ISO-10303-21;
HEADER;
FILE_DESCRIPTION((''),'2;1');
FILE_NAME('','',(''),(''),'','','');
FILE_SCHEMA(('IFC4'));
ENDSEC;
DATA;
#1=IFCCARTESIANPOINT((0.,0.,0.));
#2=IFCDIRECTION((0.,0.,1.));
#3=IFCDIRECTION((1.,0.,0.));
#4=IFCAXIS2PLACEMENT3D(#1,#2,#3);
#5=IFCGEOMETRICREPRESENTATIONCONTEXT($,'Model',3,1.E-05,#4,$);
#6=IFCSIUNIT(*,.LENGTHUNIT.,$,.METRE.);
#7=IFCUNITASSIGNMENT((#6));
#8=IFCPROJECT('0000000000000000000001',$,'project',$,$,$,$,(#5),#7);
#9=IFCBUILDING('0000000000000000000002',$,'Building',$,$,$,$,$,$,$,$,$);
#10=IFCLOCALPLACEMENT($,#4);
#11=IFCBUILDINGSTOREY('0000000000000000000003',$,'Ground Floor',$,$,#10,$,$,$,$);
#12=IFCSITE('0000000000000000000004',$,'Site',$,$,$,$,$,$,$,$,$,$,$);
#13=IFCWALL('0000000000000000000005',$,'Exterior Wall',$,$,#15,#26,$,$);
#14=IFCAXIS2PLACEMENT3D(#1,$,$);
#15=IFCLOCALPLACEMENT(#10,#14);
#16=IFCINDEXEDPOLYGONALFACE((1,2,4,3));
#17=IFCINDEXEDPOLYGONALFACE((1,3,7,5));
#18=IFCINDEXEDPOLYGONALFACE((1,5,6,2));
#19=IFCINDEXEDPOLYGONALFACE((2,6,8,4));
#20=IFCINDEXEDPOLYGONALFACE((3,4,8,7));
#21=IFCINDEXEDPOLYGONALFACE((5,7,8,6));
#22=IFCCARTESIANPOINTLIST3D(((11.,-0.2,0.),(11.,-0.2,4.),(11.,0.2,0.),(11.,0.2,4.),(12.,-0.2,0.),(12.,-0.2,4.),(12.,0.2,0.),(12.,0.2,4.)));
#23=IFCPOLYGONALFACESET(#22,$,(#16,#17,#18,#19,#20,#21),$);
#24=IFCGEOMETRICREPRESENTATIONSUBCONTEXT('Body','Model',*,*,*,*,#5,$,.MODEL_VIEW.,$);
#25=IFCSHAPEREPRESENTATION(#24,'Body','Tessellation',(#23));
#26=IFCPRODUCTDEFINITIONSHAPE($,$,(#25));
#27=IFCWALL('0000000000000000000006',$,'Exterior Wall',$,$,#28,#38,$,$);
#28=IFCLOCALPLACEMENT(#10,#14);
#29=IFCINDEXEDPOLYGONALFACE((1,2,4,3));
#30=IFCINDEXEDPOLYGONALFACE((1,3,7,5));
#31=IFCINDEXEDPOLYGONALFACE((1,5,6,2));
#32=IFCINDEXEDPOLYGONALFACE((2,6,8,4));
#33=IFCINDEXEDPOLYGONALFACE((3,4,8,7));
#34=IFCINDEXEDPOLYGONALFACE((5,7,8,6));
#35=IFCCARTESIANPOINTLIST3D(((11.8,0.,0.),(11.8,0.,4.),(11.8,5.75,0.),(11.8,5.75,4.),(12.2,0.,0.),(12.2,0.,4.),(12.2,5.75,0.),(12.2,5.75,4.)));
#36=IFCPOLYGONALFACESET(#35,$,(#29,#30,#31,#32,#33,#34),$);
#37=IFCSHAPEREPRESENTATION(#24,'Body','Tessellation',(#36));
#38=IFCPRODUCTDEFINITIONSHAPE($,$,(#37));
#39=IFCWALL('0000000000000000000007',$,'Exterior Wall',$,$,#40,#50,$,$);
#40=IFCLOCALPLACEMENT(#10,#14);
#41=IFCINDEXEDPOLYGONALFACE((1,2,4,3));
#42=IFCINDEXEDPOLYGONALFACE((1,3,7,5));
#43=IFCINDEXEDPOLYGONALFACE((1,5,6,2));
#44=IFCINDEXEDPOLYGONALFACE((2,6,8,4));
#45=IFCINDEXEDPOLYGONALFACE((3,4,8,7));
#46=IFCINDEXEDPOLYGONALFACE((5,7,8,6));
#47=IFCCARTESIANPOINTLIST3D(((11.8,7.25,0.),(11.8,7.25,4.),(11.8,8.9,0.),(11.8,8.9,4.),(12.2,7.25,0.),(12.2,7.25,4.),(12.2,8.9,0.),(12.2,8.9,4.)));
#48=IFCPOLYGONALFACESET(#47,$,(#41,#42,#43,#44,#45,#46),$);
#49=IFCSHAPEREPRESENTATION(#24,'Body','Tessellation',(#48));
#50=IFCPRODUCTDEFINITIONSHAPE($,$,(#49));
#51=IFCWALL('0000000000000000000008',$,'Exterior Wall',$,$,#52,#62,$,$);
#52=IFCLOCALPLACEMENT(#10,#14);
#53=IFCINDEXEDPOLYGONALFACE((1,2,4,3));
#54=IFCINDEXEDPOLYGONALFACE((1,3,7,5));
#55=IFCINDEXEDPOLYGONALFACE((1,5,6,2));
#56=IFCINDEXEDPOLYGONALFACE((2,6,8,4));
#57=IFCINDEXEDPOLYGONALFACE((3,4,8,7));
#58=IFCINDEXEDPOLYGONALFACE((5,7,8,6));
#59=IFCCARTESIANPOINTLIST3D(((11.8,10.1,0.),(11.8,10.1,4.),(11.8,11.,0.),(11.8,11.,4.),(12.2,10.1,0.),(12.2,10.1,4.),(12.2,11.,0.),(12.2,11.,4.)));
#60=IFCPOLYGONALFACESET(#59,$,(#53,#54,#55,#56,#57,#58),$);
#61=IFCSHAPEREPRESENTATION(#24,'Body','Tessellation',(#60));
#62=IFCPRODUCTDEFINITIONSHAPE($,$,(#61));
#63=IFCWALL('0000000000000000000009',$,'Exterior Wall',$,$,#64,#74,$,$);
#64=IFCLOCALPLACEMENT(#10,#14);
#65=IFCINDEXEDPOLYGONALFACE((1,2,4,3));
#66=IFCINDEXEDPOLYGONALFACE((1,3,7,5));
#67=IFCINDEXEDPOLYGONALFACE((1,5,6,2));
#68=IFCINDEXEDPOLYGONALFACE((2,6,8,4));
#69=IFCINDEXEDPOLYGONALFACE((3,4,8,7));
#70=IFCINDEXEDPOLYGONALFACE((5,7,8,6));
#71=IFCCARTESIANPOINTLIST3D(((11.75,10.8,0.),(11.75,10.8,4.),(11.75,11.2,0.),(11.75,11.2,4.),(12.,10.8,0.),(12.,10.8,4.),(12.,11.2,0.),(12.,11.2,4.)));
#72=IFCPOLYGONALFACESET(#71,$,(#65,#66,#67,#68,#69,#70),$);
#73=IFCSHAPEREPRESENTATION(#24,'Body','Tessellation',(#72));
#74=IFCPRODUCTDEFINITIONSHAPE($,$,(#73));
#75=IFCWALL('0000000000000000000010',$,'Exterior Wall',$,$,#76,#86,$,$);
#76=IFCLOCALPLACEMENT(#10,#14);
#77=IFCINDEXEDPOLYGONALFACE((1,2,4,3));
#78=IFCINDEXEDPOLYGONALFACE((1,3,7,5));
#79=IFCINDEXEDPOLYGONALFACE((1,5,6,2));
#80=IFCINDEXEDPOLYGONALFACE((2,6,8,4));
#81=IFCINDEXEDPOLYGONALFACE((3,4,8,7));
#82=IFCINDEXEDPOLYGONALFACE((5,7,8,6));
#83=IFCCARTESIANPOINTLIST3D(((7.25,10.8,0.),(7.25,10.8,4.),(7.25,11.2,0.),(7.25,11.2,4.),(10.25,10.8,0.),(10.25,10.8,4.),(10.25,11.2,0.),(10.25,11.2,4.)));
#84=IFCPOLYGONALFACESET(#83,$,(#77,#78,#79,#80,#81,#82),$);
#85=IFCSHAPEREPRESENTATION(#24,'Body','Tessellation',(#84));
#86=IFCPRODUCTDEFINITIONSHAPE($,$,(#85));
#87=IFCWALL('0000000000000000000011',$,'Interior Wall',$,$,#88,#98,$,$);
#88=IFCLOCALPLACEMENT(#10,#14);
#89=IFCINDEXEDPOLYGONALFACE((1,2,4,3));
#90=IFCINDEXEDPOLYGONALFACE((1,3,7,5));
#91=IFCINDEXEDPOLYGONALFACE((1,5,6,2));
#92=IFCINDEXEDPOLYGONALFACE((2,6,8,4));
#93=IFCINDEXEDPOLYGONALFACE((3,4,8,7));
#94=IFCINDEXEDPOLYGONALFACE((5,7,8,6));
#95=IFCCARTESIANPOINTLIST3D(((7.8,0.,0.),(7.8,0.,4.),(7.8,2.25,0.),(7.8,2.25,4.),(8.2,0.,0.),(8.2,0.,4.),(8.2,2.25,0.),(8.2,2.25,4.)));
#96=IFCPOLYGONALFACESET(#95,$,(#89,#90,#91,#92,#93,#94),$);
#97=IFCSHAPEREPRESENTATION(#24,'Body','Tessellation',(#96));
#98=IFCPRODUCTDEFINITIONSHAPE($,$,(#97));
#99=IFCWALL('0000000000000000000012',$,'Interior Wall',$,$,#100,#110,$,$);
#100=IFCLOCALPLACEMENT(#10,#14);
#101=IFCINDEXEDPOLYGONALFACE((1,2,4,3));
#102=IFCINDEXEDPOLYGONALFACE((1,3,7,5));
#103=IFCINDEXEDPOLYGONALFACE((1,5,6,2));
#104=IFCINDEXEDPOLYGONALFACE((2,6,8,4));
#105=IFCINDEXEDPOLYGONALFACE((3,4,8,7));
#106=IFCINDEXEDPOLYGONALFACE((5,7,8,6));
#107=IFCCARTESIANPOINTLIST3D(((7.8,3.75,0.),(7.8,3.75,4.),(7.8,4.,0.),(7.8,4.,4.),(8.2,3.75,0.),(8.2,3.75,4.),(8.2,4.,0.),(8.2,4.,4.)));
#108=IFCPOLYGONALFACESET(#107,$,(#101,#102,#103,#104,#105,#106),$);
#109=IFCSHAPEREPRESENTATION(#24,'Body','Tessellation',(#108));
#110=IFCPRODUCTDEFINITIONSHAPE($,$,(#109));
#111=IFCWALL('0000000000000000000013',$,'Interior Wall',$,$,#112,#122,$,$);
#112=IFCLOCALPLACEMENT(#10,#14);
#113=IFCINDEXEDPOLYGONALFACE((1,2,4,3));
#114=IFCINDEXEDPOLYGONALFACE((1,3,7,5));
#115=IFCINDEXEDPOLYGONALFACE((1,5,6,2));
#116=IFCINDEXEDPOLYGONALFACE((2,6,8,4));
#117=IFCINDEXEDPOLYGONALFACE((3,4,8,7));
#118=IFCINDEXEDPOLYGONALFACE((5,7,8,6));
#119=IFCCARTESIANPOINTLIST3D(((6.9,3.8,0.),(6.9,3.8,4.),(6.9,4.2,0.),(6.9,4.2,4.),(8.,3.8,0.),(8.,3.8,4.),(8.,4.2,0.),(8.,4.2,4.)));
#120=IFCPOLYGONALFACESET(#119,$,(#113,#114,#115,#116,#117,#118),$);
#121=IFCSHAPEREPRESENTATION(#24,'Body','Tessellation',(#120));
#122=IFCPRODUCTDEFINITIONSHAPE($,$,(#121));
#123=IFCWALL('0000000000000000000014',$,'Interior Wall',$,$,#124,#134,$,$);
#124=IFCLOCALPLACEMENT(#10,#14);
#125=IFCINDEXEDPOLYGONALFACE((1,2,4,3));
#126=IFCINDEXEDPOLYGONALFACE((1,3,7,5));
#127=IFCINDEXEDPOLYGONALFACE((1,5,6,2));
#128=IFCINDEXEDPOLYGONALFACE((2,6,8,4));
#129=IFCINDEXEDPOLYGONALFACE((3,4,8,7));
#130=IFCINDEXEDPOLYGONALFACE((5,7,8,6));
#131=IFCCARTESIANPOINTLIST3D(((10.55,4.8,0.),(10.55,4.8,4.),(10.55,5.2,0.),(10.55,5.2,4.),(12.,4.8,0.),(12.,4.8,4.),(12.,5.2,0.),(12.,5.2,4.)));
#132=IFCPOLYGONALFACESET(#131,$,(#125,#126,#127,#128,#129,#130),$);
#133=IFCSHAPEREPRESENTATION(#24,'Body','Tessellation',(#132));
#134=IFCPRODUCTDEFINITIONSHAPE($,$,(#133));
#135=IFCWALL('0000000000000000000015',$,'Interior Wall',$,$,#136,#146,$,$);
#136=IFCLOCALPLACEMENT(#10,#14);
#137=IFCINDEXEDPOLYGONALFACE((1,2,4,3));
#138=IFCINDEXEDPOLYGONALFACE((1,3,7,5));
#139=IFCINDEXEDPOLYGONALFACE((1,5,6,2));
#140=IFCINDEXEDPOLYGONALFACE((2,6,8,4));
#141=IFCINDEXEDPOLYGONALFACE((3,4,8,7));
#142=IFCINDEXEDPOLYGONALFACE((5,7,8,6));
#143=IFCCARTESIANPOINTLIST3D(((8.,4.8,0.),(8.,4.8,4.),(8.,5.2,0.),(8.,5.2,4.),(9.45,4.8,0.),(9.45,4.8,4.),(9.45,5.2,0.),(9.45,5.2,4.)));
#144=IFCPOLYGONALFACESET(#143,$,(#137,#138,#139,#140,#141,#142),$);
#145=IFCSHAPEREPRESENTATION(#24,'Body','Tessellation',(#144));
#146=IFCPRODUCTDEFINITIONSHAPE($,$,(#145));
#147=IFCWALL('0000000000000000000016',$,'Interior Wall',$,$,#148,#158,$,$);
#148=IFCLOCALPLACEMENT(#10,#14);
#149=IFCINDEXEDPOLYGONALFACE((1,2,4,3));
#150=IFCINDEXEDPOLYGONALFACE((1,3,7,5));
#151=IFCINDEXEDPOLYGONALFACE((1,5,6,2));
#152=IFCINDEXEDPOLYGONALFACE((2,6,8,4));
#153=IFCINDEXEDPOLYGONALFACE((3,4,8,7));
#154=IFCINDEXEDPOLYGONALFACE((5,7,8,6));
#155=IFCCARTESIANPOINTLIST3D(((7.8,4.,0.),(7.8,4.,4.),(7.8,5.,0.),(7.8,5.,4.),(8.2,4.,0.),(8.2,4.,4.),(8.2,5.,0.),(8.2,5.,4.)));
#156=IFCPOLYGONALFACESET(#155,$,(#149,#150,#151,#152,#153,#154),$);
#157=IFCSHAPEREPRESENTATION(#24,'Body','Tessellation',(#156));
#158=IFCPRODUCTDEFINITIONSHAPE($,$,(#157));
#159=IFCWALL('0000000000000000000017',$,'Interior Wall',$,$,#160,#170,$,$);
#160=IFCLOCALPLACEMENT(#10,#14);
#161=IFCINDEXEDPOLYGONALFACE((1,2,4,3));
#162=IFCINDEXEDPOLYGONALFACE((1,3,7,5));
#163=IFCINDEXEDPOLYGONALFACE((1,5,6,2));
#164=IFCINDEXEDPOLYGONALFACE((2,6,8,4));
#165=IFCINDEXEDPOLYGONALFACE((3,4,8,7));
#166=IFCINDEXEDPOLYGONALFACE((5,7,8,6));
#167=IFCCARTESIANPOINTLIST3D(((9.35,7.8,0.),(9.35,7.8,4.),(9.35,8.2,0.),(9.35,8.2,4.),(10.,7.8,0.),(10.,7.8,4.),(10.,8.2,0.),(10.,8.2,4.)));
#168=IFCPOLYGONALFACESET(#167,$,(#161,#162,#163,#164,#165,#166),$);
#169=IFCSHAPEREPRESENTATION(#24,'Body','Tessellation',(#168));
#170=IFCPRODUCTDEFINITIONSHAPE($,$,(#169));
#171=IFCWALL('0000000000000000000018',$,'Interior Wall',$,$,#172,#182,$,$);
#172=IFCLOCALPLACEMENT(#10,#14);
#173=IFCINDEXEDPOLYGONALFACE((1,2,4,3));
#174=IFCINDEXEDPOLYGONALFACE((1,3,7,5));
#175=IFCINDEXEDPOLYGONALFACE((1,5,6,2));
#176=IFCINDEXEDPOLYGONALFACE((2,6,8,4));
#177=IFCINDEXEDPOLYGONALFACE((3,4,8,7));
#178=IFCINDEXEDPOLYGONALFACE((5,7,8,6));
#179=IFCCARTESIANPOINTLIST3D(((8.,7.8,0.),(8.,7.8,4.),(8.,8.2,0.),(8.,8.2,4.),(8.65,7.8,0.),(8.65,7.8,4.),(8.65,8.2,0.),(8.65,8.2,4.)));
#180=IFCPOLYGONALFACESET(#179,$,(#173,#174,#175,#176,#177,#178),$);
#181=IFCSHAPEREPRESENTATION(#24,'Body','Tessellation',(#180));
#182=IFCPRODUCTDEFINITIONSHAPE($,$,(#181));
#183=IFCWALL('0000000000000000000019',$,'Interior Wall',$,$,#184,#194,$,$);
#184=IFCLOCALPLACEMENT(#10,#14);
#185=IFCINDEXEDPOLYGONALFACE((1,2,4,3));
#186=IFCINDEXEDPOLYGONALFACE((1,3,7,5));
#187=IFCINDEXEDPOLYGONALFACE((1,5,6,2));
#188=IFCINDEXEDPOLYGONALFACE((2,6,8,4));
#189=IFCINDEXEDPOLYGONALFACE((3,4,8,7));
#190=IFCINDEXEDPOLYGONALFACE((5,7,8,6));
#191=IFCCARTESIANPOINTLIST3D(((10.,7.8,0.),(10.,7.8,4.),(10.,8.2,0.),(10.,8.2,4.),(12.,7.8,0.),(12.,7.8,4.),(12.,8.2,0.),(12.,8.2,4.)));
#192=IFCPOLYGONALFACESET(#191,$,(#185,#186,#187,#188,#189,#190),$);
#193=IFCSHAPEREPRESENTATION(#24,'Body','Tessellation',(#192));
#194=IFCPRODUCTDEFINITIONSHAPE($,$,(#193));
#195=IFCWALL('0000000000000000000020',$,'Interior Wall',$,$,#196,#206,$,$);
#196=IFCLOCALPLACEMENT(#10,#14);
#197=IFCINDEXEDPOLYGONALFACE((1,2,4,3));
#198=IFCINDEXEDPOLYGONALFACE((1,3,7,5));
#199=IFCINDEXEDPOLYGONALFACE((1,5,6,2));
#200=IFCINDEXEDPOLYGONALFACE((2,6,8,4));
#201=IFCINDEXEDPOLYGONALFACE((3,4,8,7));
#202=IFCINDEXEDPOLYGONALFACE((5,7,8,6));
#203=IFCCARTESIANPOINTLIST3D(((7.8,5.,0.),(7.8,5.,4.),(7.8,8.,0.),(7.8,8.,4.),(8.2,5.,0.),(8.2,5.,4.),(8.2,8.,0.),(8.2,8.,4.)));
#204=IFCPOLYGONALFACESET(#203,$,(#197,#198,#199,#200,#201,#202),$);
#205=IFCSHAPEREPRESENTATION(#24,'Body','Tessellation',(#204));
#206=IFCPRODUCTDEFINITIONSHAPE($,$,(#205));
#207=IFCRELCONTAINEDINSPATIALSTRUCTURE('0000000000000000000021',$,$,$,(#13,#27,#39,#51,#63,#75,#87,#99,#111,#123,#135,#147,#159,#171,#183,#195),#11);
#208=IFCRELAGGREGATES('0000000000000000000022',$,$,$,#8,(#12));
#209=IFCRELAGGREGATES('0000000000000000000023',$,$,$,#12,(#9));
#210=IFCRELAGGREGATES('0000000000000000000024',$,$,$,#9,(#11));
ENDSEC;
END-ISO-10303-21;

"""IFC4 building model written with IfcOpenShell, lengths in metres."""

from ifc_helpers import new_model, si_unit, frame, origin_with_axes, place, context, subcontext, project, spatial, indexed_curve, outline, extrude, element, save


model = new_model("IFC4")

# Units and contexts
model_context = context("Model", 3, precision=1e-05, world=origin_with_axes())
body_context = subcontext(model_context, "Body", "Model", "MODEL_VIEW")
ifc_project = project(units=[si_unit("LENGTHUNIT", "METRE")], contexts=[model_context])

# Site, building, storey
site = spatial("IfcSite", under=ifc_project, Name="Site")
building = spatial("IfcBuilding", under=site, Name="Building")
storey_placement = place(None, origin_with_axes())
storey = spatial("IfcBuildingStorey", under=building, at=storey_placement, Name="Ground Floor")

# Walls
wall_1_placement = place(storey_placement, frame((11.0, 0.0, 0.0), z_axis=(0.0, 0.0, 1.0), x_axis=(1.0, 0.0, 0.0)))
element("IfcWall", 1, at=wall_1_placement, inside=storey, Name="Exterior Wall", context=body_context, shape_type="SweptSolid", body=[
    extrude(outline(indexed_curve([(0.0, 0.0), (0.0, 0.4), (1.0, 0.4), (1.0, 0.0), (0.0, 0.0)], self_intersect=False)), frame((0.0, -0.2, 0.0), z_axis=(0.0, 0.0, 1.0), x_axis=(1.0, 0.0, 0.0)), (0.0, 0.0, 1.0), 4.0),
])
wall_2_placement = place(storey_placement, frame((12.0, 0.0, 0.0), z_axis=(0.0, 0.0, 1.0), x_axis=(0.0, 1.0, 0.0)))
element("IfcWall", 2, at=wall_2_placement, inside=storey, Name="Exterior Wall", context=body_context, shape_type="SweptSolid", body=[
    extrude(outline(indexed_curve([(0.0, 0.0), (0.0, 0.4), (5.75, 0.4), (5.75, 0.0), (0.0, 0.0)], self_intersect=False)), frame((0.0, -0.2, 0.0), z_axis=(0.0, 0.0, 1.0), x_axis=(1.0, 0.0, 0.0)), (0.0, 0.0, 1.0), 4.0),
])
wall_3_placement = place(storey_placement, frame((12.0, 7.25, 0.0), z_axis=(0.0, 0.0, 1.0), x_axis=(0.0, 1.0, 0.0)))
element("IfcWall", 3, at=wall_3_placement, inside=storey, Name="Exterior Wall", context=body_context, shape_type="SweptSolid", body=[
    extrude(outline(indexed_curve([(0.0, 0.0), (0.0, 0.4), (1.65, 0.4), (1.65, 0.0), (0.0, 0.0)], self_intersect=False)), frame((0.0, -0.2, 0.0), z_axis=(0.0, 0.0, 1.0), x_axis=(1.0, 0.0, 0.0)), (0.0, 0.0, 1.0), 4.0),
])
wall_4_placement = place(storey_placement, frame((12.0, 10.1, 0.0), z_axis=(0.0, 0.0, 1.0), x_axis=(0.0, 1.0, 0.0)))
element("IfcWall", 4, at=wall_4_placement, inside=storey, Name="Exterior Wall", context=body_context, shape_type="SweptSolid", body=[
    extrude(outline(indexed_curve([(0.0, 0.0), (0.0, 0.4), (0.9, 0.4), (0.9, 0.0), (0.0, 0.0)], self_intersect=False)), frame((0.0, -0.2, 0.0), z_axis=(0.0, 0.0, 1.0), x_axis=(1.0, 0.0, 0.0)), (0.0, 0.0, 1.0), 4.0),
])
wall_5_placement = place(storey_placement, frame((12.0, 11.0, 0.0), z_axis=(0.0, 0.0, 1.0), x_axis=(-1.0, 0.0, 0.0)))
element("IfcWall", 5, at=wall_5_placement, inside=storey, Name="Exterior Wall", context=body_context, shape_type="SweptSolid", body=[
    extrude(outline(indexed_curve([(0.0, 0.0), (0.0, 0.4), (0.25, 0.4), (0.25, 0.0), (0.0, 0.0)], self_intersect=False)), frame((0.0, -0.2, 0.0), z_axis=(0.0, 0.0, 1.0), x_axis=(1.0, 0.0, 0.0)), (0.0, 0.0, 1.0), 4.0),
])
wall_6_placement = place(storey_placement, frame((10.25, 11.0, 0.0), z_axis=(0.0, 0.0, 1.0), x_axis=(-1.0, 0.0, 0.0)))
element("IfcWall", 6, at=wall_6_placement, inside=storey, Name="Exterior Wall", context=body_context, shape_type="SweptSolid", body=[
    extrude(outline(indexed_curve([(0.0, 0.0), (0.0, 0.4), (3.0, 0.4), (3.0, 0.0), (0.0, 0.0)], self_intersect=False)), frame((0.0, -0.2, 0.0), z_axis=(0.0, 0.0, 1.0), x_axis=(1.0, 0.0, 0.0)), (0.0, 0.0, 1.0), 4.0),
])
wall_7_placement = place(storey_placement, frame((8.0, 0.0, 0.0), z_axis=(0.0, 0.0, 1.0), x_axis=(0.0, 1.0, 0.0)))
element("IfcWall", 7, at=wall_7_placement, inside=storey, Name="Interior Wall", context=body_context, shape_type="SweptSolid", body=[
    extrude(outline(indexed_curve([(0.0, 0.0), (0.0, 0.4), (2.25, 0.4), (2.25, 0.0), (0.0, 0.0)], self_intersect=False)), frame((0.0, -0.2, 0.0), z_axis=(0.0, 0.0, 1.0), x_axis=(1.0, 0.0, 0.0)), (0.0, 0.0, 1.0), 4.0),
])
wall_8_placement = place(storey_placement, frame((8.0, 3.75, 0.0), z_axis=(0.0, 0.0, 1.0), x_axis=(0.0, 1.0, 0.0)))
element("IfcWall", 8, at=wall_8_placement, inside=storey, Name="Interior Wall", context=body_context, shape_type="SweptSolid", body=[
    extrude(outline(indexed_curve([(0.0, 0.0), (0.0, 0.4), (0.25, 0.4), (0.25, 0.0), (0.0, 0.0)], self_intersect=False)), frame((0.0, -0.2, 0.0), z_axis=(0.0, 0.0, 1.0), x_axis=(1.0, 0.0, 0.0)), (0.0, 0.0, 1.0), 4.0),
])
wall_9_placement = place(storey_placement, frame((8.0, 4.0, 0.0), z_axis=(0.0, 0.0, 1.0), x_axis=(-1.0, 0.0, 0.0)))
element("IfcWall", 9, at=wall_9_placement, inside=storey, Name="Interior Wall", context=body_context, shape_type="SweptSolid", body=[
    extrude(outline(indexed_curve([(0.0, 0.0), (0.0, 0.4), (1.1, 0.4), (1.1, 0.0), (0.0, 0.0)], self_intersect=False)), frame((0.0, -0.2, 0.0), z_axis=(0.0, 0.0, 1.0), x_axis=(1.0, 0.0, 0.0)), (0.0, 0.0, 1.0), 4.0),
])
for number, where, z_axis, x_axis, name in (
    (10, (12.0, 5.0, 0.0), (0.0, 0.0, 1.0), (-1.0, 0.0, 0.0), "Interior Wall"),
    (11, (9.45, 5.0, 0.0), (0.0, 0.0, 1.0), (-1.0, 0.0, 0.0), "Interior Wall"),
):
    element("IfcWall", number, at=place(storey_placement, frame(where, z_axis=z_axis, x_axis=x_axis)), inside=storey, Name=name, context=body_context, shape_type="SweptSolid", body=[
        extrude(outline(indexed_curve([(0.0, 0.0), (0.0, 0.4), (1.45, 0.4), (1.45, 0.0), (0.0, 0.0)], self_intersect=False)), frame((0.0, -0.2, 0.0), z_axis=(0.0, 0.0, 1.0), x_axis=(1.0, 0.0, 0.0)), (0.0, 0.0, 1.0), 4.0),
    ])
wall_10_placement = place(storey_placement, frame((8.0, 5.0, 0.0), z_axis=(0.0, 0.0, 1.0), x_axis=(0.0, -1.0, 0.0)))
element("IfcWall", 12, at=wall_10_placement, inside=storey, Name="Interior Wall", context=body_context, shape_type="SweptSolid", body=[
    extrude(outline(indexed_curve([(0.0, 0.0), (0.0, 0.4), (1.0, 0.4), (1.0, 0.0), (0.0, 0.0)], self_intersect=False)), frame((0.0, -0.2, 0.0), z_axis=(0.0, 0.0, 1.0), x_axis=(1.0, 0.0, 0.0)), (0.0, 0.0, 1.0), 4.0),
])
for number, where, z_axis, x_axis, name in (
    (13, (10.0, 8.0, 0.0), (0.0, 0.0, 1.0), (-1.0, 0.0, 0.0), "Interior Wall"),
    (14, (8.65, 8.0, 0.0), (0.0, 0.0, 1.0), (-1.0, 0.0, 0.0), "Interior Wall"),
):
    element("IfcWall", number, at=place(storey_placement, frame(where, z_axis=z_axis, x_axis=x_axis)), inside=storey, Name=name, context=body_context, shape_type="SweptSolid", body=[
        extrude(outline(indexed_curve([(0.0, 0.0), (0.0, 0.4), (0.65, 0.4), (0.65, 0.0), (0.0, 0.0)], self_intersect=False)), frame((0.0, -0.2, 0.0), z_axis=(0.0, 0.0, 1.0), x_axis=(1.0, 0.0, 0.0)), (0.0, 0.0, 1.0), 4.0),
    ])
wall_11_placement = place(storey_placement, frame((12.0, 8.0, 0.0), z_axis=(0.0, 0.0, 1.0), x_axis=(-1.0, 0.0, 0.0)))
element("IfcWall", 15, at=wall_11_placement, inside=storey, Name="Interior Wall", context=body_context, shape_type="SweptSolid", body=[
    extrude(outline(indexed_curve([(0.0, 0.0), (0.0, 0.4), (2.0, 0.4), (2.0, 0.0), (0.0, 0.0)], self_intersect=False)), frame((0.0, -0.2, 0.0), z_axis=(0.0, 0.0, 1.0), x_axis=(1.0, 0.0, 0.0)), (0.0, 0.0, 1.0), 4.0),
])
wall_12_placement = place(storey_placement, frame((8.0, 8.0, 0.0), z_axis=(0.0, 0.0, 1.0), x_axis=(0.0, -1.0, 0.0)))
element("IfcWall", 16, at=wall_12_placement, inside=storey, Name="Interior Wall", context=body_context, shape_type="SweptSolid", body=[
    extrude(outline(indexed_curve([(0.0, 0.0), (0.0, 0.4), (3.0, 0.4), (3.0, 0.0), (0.0, 0.0)], self_intersect=False)), frame((0.0, -0.2, 0.0), z_axis=(0.0, 0.0, 1.0), x_axis=(1.0, 0.0, 0.0)), (0.0, 0.0, 1.0), 4.0),
])

save(model, "model.ifc")
